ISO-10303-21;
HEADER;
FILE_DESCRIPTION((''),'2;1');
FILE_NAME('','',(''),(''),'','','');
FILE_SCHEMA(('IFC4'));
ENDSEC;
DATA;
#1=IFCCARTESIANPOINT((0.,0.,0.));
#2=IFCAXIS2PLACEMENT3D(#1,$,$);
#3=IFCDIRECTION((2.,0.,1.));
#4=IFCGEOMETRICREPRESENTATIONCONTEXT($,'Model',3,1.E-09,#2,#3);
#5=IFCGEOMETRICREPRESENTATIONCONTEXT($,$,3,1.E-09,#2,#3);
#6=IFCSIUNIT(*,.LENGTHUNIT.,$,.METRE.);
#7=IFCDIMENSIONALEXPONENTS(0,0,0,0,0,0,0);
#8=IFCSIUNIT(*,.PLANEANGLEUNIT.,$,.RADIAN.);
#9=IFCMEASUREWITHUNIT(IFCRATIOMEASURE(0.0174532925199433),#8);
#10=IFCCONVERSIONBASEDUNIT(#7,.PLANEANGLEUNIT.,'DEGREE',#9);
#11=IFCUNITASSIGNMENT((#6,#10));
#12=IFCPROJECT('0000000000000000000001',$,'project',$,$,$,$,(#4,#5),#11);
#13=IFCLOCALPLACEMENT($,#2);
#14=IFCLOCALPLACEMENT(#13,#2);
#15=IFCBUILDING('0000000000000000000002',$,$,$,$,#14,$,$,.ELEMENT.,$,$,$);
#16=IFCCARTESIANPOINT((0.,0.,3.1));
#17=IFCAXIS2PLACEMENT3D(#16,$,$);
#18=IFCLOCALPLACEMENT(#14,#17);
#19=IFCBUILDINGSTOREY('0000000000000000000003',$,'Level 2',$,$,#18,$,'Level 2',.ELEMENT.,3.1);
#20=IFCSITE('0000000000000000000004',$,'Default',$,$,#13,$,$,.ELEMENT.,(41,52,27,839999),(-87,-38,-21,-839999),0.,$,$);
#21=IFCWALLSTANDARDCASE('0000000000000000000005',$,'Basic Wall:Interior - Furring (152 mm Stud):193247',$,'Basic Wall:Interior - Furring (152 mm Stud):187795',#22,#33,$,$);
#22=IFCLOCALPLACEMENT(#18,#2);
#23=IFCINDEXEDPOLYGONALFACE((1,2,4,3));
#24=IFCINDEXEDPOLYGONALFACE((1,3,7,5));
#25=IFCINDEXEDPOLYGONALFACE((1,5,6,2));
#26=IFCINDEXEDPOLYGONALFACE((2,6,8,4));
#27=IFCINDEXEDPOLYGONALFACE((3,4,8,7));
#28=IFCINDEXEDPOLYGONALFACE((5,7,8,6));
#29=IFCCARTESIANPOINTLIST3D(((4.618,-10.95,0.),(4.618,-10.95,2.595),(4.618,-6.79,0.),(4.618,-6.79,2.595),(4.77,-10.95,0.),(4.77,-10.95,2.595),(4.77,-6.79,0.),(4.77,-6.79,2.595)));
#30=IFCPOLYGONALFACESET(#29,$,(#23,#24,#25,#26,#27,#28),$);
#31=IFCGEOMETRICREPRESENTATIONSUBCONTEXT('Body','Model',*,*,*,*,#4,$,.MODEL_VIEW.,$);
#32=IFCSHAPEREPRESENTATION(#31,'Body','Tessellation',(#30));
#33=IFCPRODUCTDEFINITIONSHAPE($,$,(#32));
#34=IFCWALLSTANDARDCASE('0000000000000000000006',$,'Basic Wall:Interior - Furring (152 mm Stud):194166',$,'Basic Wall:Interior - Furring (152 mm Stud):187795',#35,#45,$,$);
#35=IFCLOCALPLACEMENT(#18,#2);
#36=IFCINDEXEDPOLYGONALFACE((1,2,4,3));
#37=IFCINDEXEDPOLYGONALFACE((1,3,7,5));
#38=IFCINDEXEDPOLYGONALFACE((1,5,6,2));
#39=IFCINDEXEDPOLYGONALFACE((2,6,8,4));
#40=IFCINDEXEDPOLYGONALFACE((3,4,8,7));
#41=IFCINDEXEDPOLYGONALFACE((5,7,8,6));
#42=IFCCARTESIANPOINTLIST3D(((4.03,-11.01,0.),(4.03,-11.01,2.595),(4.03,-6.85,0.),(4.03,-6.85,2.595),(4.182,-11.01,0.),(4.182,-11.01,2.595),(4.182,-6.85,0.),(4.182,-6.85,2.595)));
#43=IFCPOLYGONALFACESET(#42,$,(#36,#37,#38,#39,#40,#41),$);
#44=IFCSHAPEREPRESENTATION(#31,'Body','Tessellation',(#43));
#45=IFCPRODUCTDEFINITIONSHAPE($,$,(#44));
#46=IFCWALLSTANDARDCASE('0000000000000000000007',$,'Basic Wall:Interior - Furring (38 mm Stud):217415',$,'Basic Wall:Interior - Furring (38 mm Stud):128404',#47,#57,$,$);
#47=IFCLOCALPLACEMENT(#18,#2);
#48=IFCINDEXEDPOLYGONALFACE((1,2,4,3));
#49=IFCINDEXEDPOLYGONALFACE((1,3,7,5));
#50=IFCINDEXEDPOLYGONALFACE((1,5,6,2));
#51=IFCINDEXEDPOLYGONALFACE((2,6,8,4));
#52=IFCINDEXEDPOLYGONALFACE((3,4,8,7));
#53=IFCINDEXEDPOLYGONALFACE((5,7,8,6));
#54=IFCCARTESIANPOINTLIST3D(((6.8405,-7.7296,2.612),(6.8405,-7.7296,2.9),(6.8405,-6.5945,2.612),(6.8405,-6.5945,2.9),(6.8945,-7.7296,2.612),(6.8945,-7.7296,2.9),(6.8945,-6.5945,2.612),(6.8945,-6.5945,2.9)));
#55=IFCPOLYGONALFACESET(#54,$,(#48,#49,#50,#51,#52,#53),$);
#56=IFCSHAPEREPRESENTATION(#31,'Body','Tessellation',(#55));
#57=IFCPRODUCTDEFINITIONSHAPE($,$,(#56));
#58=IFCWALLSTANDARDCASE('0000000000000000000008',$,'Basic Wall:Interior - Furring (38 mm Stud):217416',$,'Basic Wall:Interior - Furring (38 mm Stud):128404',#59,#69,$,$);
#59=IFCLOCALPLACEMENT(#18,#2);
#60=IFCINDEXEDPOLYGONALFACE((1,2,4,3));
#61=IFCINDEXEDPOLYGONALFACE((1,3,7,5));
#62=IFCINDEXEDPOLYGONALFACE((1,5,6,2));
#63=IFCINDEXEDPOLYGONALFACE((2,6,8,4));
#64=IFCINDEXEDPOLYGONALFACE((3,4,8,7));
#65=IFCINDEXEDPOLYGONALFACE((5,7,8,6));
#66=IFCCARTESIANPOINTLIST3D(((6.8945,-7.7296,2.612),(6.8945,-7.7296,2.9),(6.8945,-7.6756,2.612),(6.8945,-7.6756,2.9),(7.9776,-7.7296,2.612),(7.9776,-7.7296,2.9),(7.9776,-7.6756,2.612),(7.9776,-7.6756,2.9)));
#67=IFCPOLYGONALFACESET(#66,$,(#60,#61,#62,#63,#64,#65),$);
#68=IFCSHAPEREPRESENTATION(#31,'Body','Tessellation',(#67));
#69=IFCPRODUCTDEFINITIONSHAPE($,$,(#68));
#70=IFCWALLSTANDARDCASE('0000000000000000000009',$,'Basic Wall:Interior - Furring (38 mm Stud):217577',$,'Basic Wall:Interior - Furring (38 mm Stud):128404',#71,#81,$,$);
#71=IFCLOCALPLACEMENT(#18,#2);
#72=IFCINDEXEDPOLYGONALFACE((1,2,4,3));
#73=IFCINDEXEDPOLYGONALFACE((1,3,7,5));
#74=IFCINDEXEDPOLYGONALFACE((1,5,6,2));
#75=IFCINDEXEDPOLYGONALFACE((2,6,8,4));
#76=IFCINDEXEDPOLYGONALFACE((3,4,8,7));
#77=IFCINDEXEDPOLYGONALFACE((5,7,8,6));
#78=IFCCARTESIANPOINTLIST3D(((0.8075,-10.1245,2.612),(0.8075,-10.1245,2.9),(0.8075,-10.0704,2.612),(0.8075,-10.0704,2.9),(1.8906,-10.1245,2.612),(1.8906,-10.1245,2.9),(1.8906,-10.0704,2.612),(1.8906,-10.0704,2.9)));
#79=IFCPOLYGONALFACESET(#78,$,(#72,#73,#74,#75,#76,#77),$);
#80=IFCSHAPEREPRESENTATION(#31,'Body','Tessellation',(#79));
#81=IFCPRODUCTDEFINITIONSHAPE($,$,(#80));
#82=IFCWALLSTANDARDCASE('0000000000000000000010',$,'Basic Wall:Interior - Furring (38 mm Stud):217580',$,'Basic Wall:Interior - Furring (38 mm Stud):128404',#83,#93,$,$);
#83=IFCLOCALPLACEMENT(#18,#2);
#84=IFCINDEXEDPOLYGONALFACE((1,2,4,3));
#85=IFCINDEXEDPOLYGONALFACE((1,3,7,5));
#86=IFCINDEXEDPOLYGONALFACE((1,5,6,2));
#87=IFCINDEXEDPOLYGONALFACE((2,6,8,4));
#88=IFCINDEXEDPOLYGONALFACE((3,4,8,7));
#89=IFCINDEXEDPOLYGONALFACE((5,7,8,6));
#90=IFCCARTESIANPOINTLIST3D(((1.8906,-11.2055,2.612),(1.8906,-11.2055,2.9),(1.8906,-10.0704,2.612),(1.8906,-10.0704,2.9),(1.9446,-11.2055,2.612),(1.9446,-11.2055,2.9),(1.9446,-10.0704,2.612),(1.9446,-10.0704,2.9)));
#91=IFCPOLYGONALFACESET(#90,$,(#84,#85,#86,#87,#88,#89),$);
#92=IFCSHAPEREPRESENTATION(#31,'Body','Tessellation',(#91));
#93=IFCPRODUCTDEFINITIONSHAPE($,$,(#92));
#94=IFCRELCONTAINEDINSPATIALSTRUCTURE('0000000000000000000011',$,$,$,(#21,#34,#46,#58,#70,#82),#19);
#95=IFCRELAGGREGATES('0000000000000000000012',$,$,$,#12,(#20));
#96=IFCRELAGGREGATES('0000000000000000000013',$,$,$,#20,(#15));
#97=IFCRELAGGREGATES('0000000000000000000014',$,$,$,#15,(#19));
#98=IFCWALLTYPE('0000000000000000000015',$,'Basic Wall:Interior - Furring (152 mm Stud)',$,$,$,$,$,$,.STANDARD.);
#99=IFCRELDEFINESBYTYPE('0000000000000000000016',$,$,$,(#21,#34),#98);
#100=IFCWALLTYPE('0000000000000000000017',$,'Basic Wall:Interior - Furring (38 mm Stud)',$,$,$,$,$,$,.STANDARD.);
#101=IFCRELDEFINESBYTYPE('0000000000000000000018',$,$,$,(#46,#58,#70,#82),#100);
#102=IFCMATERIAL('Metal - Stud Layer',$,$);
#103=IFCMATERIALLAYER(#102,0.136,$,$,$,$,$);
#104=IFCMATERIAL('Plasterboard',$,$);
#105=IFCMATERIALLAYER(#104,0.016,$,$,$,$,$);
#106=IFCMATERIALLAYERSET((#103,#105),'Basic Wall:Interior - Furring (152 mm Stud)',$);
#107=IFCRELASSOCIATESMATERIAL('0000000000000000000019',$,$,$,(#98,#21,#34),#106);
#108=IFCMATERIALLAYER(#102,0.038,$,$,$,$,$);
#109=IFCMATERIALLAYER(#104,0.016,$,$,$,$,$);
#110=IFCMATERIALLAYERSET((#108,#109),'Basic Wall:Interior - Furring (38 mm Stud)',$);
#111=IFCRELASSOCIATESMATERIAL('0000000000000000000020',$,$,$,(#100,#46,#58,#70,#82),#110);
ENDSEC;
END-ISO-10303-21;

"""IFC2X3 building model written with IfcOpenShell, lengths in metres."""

from ifc_helpers import new_model, entity, si_unit, converted_unit, direction, frame, frame_2d, origin, place, context, subcontext, project, spatial, rectangle, extrude, material, layer, layer_set, layer_usage, type_object, element, save


model = new_model("IFC2X3")

# Units and contexts
model_context = context("Model", 3, precision=1e-09, world=origin(), true_north=direction((2.0, 0.0, 1.0)))
context_of_model = context(None, 3, precision=1e-09, world=origin(), true_north=direction((2.0, 0.0, 1.0)))
body_context = subcontext(model_context, "Body", "Model", "MODEL_VIEW")
ifc_project = project(units=[si_unit("LENGTHUNIT", "METRE"), converted_unit("PLANEANGLEUNIT", "DEGREE", entity("IfcRatioMeasure", 0.0174532925199433), si_unit("PLANEANGLEUNIT", "RADIAN"), dimensions=[0, 0, 0, 0, 0, 0, 0])], contexts=[model_context, context_of_model])

# Site, building, storey
site_placement = place(None, origin())
site = spatial("IfcSite", under=ifc_project, at=site_placement, Name="Default", CompositionType="ELEMENT", RefLatitude=(41, 52, 27, 839999), RefLongitude=(-87, -38, -21, -839999), RefElevation=0.0)
building_placement = place(site_placement, origin())
building = spatial("IfcBuilding", under=site, at=building_placement, CompositionType="ELEMENT")
storey_placement = place(building_placement, frame((0.0, 0.0, 3.1)))
storey = spatial("IfcBuildingStorey", under=building, at=storey_placement, Name="Level 2", LongName="Level 2", CompositionType="ELEMENT", Elevation=3.1)

# Shared definitions
ifc_material_1 = material(Name="Plasterboard")
ifc_material_2 = material(Name="Metal - Stud Layer")

# Walls
ifc_layer_1 = layer(ifc_material_2, 0.136)
ifc_layer_2 = layer(ifc_material_1, 0.016)
ifc_layer_set_1 = layer_set([ifc_layer_1, ifc_layer_2], Name="Basic Wall:Interior - Furring (152 mm Stud)")
ifc_layer_usage_1 = layer_usage(ifc_layer_set_1, "AXIS2", "POSITIVE", -0.076)
wall_type_1 = type_object("IfcWallType", Name="Basic Wall:Interior - Furring (152 mm Stud)", PredefinedType="STANDARD", material=ifc_layer_set_1)
wall_1_placement = place(storey_placement, frame((4.694, -6.79, 0.0), z_axis=(0.0, 0.0, 1.0), x_axis=(0.0, -1.0, 0.0)))
element("IfcWallStandardCase", 1, at=wall_1_placement, inside=storey, type_object=wall_type_1, material=ifc_layer_usage_1, Name="Basic Wall:Interior - Furring (152 mm Stud):193247", ObjectType="Basic Wall:Interior - Furring (152 mm Stud):187795", context=body_context, shape_type="SweptSolid", body=[
    extrude(rectangle(XDim=4.16, YDim=0.152, at=frame_2d((2.08, 0.0), x_axis=(-1.0, 0.0))), origin(), (0.0, 0.0, 1.0), 2.595),
])
ifc_layer_usage_2 = layer_usage(ifc_layer_set_1, "AXIS2", "POSITIVE", -0.076)
wall_2_placement = place(storey_placement, frame((4.106, -11.01, 0.0), z_axis=(0.0, 0.0, 1.0), x_axis=(0.0, 1.0, 0.0)))
element("IfcWallStandardCase", 2, at=wall_2_placement, inside=storey, type_object=wall_type_1, material=ifc_layer_usage_2, Name="Basic Wall:Interior - Furring (152 mm Stud):194166", ObjectType="Basic Wall:Interior - Furring (152 mm Stud):187795", context=body_context, shape_type="SweptSolid", body=[
    extrude(rectangle(XDim=4.16, YDim=0.152, at=frame_2d((2.08, 0.0), x_axis=(-1.0, 0.0))), origin(), (0.0, 0.0, 1.0), 2.595),
])
ifc_layer_3 = layer(ifc_material_2, 0.038)
ifc_layer_4 = layer(ifc_material_1, 0.016)
ifc_layer_set_2 = layer_set([ifc_layer_3, ifc_layer_4], Name="Basic Wall:Interior - Furring (38 mm Stud)")
ifc_layer_usage_3 = layer_usage(ifc_layer_set_2, "AXIS2", "NEGATIVE", 0.027)
wall_type_2 = type_object("IfcWallType", Name="Basic Wall:Interior - Furring (38 mm Stud)", PredefinedType="STANDARD", material=ifc_layer_set_2)
wall_3_placement = place(storey_placement, frame((6.8675, -7.7296, 2.612), z_axis=(0.0, 0.0, 1.0), x_axis=(0.0, 1.0, 0.0)))
element("IfcWallStandardCase", 3, at=wall_3_placement, inside=storey, type_object=wall_type_2, material=ifc_layer_usage_3, Name="Basic Wall:Interior - Furring (38 mm Stud):217415", ObjectType="Basic Wall:Interior - Furring (38 mm Stud):128404", context=body_context, shape_type="SweptSolid", body=[
    extrude(rectangle(XDim=1.1351, YDim=0.054, at=frame_2d((0.5675, 0.0), x_axis=(-1.0, 0.0))), origin(), (0.0, 0.0, 1.0), 0.288),
])
ifc_layer_usage_4 = layer_usage(ifc_layer_set_2, "AXIS2", "NEGATIVE", 0.027)
wall_4_placement = place(storey_placement, frame((7.9776, -7.7026, 2.612), z_axis=(0.0, 0.0, 1.0), x_axis=(-1.0, 0.0, 0.0)))
element("IfcWallStandardCase", 4, at=wall_4_placement, inside=storey, type_object=wall_type_2, material=ifc_layer_usage_4, Name="Basic Wall:Interior - Furring (38 mm Stud):217416", ObjectType="Basic Wall:Interior - Furring (38 mm Stud):128404", context=body_context, shape_type="SweptSolid", body=[
    extrude(rectangle(XDim=1.0831, YDim=0.054, at=frame_2d((0.5415, 0.0), x_axis=(-1.0, 0.0))), origin(), (0.0, 0.0, 1.0), 0.288),
])
ifc_layer_usage_5 = layer_usage(ifc_layer_set_2, "AXIS2", "NEGATIVE", 0.027)
wall_5_placement = place(storey_placement, frame((0.8075, -10.0975, 2.612)))
element("IfcWallStandardCase", 5, at=wall_5_placement, inside=storey, type_object=wall_type_2, material=ifc_layer_usage_5, Name="Basic Wall:Interior - Furring (38 mm Stud):217577", ObjectType="Basic Wall:Interior - Furring (38 mm Stud):128404", context=body_context, shape_type="SweptSolid", body=[
    extrude(rectangle(XDim=1.0831, YDim=0.054, at=frame_2d((0.5415, 0.0), x_axis=(-1.0, 0.0))), origin(), (0.0, 0.0, 1.0), 0.288),
])
ifc_layer_usage_6 = layer_usage(ifc_layer_set_2, "AXIS2", "NEGATIVE", 0.027)
wall_6_placement = place(storey_placement, frame((1.9176, -10.0704, 2.612), z_axis=(0.0, 0.0, 1.0), x_axis=(0.0, -1.0, 0.0)))
element("IfcWallStandardCase", 6, at=wall_6_placement, inside=storey, type_object=wall_type_2, material=ifc_layer_usage_6, Name="Basic Wall:Interior - Furring (38 mm Stud):217580", ObjectType="Basic Wall:Interior - Furring (38 mm Stud):128404", context=body_context, shape_type="SweptSolid", body=[
    extrude(rectangle(XDim=1.1351, YDim=0.054, at=frame_2d((0.5675, 0.0), x_axis=(-1.0, 0.0))), origin(), (0.0, 0.0, 1.0), 0.288),
])

save(model, "model.ifc")
